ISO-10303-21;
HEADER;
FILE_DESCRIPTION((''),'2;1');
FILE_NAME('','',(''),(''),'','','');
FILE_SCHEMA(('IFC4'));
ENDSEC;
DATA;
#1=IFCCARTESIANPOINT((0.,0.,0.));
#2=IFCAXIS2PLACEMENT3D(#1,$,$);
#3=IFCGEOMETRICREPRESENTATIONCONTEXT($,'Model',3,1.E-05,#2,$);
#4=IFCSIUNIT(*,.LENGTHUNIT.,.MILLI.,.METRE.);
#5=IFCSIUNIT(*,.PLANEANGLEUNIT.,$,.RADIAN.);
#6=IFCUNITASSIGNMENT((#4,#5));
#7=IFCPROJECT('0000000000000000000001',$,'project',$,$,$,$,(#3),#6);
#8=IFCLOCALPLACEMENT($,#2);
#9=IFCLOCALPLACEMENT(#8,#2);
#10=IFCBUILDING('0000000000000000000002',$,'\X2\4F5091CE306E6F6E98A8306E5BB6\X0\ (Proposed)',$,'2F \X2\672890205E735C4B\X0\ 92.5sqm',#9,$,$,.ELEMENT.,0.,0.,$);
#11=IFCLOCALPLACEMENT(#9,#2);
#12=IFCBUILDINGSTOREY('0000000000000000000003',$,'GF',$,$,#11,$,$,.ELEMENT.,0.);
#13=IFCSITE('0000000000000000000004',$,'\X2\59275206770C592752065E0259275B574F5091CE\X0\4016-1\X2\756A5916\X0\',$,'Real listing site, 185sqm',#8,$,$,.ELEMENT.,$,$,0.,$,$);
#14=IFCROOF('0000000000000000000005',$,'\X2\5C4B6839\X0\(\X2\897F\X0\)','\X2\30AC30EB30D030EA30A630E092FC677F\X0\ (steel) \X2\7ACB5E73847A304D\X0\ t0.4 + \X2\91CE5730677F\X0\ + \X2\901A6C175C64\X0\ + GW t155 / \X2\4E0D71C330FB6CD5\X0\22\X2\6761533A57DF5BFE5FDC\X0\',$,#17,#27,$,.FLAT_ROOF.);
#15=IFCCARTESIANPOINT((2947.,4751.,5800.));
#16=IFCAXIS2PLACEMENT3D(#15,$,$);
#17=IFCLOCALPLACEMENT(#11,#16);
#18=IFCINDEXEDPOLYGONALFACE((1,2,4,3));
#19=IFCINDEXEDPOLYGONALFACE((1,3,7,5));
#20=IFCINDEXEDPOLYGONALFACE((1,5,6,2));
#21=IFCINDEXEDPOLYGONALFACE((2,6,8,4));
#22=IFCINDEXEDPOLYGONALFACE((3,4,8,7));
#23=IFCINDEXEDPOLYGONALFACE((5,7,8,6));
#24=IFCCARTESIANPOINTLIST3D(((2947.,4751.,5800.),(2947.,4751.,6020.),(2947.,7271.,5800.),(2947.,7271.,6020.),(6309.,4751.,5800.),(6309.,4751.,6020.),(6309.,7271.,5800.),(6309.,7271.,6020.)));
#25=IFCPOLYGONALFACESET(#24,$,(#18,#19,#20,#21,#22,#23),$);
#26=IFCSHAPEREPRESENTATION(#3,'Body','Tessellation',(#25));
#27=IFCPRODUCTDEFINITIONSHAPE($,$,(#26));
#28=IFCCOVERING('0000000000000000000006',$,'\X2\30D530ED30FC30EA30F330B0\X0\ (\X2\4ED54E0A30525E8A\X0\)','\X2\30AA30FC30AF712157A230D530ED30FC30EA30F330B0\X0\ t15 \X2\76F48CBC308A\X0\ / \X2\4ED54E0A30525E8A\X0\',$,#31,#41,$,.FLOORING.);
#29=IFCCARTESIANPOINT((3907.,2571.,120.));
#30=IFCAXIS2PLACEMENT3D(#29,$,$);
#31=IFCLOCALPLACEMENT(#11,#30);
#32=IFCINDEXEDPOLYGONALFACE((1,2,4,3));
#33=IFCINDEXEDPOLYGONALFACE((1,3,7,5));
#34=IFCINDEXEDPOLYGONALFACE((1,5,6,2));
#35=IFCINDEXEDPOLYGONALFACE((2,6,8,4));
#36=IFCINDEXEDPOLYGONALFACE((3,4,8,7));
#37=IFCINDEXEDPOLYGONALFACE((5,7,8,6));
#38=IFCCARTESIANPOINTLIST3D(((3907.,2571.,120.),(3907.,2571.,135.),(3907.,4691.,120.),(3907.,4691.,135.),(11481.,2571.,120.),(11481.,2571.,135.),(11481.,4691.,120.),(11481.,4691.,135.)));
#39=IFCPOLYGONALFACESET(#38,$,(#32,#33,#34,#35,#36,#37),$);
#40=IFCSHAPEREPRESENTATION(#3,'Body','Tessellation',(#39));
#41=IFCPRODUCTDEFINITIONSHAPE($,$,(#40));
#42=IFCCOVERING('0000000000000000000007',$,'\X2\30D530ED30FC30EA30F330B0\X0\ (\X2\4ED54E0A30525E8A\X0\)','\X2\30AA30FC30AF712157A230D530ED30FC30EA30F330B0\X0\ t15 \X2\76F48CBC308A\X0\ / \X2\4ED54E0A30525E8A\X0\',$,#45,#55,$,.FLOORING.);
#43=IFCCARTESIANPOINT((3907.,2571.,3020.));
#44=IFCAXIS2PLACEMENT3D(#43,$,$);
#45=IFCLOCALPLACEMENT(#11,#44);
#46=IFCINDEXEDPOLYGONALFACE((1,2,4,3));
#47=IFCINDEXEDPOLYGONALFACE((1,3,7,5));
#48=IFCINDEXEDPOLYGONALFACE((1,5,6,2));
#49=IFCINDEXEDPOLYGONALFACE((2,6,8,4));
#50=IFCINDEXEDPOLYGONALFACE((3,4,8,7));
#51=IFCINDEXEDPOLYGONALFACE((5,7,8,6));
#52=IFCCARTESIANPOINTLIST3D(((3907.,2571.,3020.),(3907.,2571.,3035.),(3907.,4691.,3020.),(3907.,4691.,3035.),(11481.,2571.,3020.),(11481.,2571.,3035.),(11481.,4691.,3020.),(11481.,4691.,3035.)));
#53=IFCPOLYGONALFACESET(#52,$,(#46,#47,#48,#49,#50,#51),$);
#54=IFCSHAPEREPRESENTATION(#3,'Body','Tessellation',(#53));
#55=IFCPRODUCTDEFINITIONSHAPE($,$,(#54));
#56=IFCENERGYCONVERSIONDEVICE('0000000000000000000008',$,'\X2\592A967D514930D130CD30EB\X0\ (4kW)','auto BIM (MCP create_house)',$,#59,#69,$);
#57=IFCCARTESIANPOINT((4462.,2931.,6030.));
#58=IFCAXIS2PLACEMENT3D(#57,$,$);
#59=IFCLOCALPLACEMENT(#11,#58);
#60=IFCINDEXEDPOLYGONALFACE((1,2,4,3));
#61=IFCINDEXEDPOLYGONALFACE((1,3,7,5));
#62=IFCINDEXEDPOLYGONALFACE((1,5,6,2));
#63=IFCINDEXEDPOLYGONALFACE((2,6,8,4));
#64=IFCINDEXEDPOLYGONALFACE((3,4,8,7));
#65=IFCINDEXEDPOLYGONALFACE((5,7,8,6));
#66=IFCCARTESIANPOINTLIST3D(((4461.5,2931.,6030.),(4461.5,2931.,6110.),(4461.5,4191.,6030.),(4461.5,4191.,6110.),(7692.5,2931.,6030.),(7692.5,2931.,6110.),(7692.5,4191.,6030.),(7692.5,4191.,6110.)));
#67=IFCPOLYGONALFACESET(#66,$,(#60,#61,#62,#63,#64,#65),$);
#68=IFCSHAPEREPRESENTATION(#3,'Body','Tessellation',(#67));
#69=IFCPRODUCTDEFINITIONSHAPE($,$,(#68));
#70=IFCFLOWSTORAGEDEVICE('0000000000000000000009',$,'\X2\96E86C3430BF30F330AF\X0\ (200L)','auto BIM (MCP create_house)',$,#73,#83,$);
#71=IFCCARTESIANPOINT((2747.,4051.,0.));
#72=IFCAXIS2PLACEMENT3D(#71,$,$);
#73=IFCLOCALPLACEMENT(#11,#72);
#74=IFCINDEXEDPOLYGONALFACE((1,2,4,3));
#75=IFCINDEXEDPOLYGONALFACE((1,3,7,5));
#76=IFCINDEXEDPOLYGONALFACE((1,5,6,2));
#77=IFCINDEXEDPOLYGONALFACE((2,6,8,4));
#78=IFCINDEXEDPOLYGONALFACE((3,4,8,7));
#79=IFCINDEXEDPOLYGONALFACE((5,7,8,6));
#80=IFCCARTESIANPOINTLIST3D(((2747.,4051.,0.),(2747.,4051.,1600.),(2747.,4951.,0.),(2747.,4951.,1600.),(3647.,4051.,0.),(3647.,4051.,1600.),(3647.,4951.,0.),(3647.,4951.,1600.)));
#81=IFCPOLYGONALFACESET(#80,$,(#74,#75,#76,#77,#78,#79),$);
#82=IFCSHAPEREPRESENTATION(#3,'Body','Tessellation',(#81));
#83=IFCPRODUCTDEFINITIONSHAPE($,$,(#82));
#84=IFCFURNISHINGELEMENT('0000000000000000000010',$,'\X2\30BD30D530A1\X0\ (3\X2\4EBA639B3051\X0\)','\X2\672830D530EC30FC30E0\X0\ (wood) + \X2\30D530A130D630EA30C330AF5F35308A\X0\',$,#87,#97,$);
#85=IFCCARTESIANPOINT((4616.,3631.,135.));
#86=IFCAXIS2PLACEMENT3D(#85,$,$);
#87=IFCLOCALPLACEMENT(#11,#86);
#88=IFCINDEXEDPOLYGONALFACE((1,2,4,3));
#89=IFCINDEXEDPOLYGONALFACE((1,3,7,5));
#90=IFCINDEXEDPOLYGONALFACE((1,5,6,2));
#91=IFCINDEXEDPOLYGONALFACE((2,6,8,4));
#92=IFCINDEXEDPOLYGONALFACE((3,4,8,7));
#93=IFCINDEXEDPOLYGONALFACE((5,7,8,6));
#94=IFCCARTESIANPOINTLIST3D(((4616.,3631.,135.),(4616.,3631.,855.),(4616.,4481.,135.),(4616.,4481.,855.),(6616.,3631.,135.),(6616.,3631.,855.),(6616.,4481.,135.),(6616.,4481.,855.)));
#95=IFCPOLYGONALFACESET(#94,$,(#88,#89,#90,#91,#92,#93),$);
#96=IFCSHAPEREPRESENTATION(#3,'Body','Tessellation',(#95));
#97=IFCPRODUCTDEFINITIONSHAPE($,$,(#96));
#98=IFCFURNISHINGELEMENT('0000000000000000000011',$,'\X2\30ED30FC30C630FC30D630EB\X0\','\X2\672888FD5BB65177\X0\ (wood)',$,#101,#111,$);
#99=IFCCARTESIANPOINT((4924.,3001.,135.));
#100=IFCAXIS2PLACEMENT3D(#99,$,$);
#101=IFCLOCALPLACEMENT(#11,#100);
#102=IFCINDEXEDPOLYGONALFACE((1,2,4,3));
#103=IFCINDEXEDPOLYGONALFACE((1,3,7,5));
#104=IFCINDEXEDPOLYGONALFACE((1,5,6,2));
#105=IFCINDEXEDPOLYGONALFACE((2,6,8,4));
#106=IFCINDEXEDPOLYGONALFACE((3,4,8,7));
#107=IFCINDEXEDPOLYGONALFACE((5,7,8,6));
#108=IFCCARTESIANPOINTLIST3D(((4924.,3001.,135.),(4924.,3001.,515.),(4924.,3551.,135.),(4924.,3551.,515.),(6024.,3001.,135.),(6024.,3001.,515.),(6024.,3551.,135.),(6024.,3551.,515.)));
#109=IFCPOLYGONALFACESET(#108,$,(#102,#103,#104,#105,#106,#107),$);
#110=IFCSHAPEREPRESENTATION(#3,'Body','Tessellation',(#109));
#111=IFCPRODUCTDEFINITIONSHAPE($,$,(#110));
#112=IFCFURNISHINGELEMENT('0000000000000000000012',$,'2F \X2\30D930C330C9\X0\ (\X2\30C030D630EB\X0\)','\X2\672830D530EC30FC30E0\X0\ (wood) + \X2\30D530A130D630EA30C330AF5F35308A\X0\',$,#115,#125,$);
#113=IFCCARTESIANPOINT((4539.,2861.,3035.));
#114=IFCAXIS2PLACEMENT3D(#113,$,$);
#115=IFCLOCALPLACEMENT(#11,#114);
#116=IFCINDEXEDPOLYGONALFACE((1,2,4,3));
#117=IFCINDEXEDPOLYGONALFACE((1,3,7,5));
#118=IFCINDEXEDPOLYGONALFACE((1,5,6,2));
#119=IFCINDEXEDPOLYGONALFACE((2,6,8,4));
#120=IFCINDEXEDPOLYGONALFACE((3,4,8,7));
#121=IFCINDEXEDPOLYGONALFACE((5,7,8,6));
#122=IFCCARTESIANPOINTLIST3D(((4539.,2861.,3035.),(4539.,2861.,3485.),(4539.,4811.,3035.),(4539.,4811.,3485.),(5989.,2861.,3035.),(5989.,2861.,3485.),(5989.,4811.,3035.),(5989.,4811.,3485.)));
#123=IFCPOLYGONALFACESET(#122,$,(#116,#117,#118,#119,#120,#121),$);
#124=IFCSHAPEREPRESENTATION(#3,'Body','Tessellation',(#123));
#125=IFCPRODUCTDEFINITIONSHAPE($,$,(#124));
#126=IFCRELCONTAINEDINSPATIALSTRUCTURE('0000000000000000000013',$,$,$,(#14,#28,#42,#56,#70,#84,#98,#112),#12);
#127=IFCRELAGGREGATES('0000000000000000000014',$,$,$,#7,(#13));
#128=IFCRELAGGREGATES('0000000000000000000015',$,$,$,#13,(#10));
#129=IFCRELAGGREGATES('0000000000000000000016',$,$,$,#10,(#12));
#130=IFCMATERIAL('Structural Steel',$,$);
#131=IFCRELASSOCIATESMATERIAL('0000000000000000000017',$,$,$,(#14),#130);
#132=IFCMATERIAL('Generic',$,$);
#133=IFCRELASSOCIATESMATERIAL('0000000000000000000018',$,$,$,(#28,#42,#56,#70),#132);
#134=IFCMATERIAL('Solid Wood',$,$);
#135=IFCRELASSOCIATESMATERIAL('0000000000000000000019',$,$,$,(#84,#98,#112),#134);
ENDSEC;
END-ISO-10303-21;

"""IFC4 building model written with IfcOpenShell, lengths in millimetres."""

from ifc_helpers import new_model, si_unit, frame, frame_2d, origin, place, context, project, spatial, rectangle, extrude, material, element, save


model = new_model("IFC4")

# Units and contexts
model_context = context("Model", 3, precision=1e-05, world=origin())
ifc_project = project(units=[si_unit("LENGTHUNIT", "METRE", prefix="MILLI"), si_unit("PLANEANGLEUNIT", "RADIAN")], contexts=[model_context])

# Site, building, storey
site_placement = place(None, origin())
site = spatial("IfcSite", under=ifc_project, at=site_placement, Name="大分県大分市大字佐野4016-1番外", ObjectType="Real listing site, 185sqm", CompositionType="ELEMENT", RefElevation=0.0)
building_placement = place(site_placement, origin())
building = spatial("IfcBuilding", under=site, at=building_placement, Name="佐野の潮風の家 (Proposed)", ObjectType="2F 木造平屋 92.5sqm", CompositionType="ELEMENT", ElevationOfRefHeight=0.0, ElevationOfTerrain=0.0)
storey_placement = place(building_placement, origin())
storey = spatial("IfcBuildingStorey", under=building, at=storey_placement, Name="GF", CompositionType="ELEMENT", Elevation=0.0)

# Shared definitions
ifc_material_1 = material(Name="Solid Wood")

# Roof
ifc_material_2 = material(Name="Structural Steel")
roof_1_placement = place(storey_placement, frame((2947.0, 4751.0, 5800.0)))
element("IfcRoof", 1, at=roof_1_placement, inside=storey, material=ifc_material_2, Name="屋根(西)", Description="ガルバリウム鋼板 (steel) 立平葺き t0.4 + 野地板 + 通気層 + GW t155 / 不燃・法22条区域対応", PredefinedType="FLAT_ROOF", context=model_context, shape_type="SweptSolid", body=[
    extrude(rectangle(XDim=3362.0, YDim=2520.0, at=frame_2d((1681.0, 1260.0))), frame((2947.0, 4751.0, 5800.0)), (0.0, 0.0, 1.0), 220.0),
])

# Coverings
ifc_material_3 = material(Name="Generic")
covering_1_placement = place(storey_placement, frame((3907.0, 2571.0, 120.0)))
element("IfcCovering", 2, at=covering_1_placement, inside=storey, material=ifc_material_3, Name="フローリング (仕上げ床)", Description="オーク無垢フローリング t15 直貼り / 仕上げ床", PredefinedType="FLOORING", context=model_context, shape_type="SweptSolid", body=[
    extrude(rectangle(XDim=7574.0, YDim=2120.0, at=frame_2d((3787.0, 1060.0))), frame((3907.0, 2571.0, 120.0)), (0.0, 0.0, 1.0), 15.0),
])
covering_2_placement = place(storey_placement, frame((3907.0, 2571.0, 3020.0)))
element("IfcCovering", 3, at=covering_2_placement, inside=storey, material=ifc_material_3, Name="フローリング (仕上げ床)", Description="オーク無垢フローリング t15 直貼り / 仕上げ床", PredefinedType="FLOORING", context=model_context, shape_type="SweptSolid", body=[
    extrude(rectangle(XDim=7574.0, YDim=2120.0, at=frame_2d((3787.0, 1060.0))), frame((3907.0, 2571.0, 3020.0)), (0.0, 0.0, 1.0), 15.0),
])

# Energy conversion device
energy_conversion_device_placement = place(storey_placement, frame((4462.0, 2931.0, 6030.0)))
element("IfcEnergyConversionDevice", 4, at=energy_conversion_device_placement, inside=storey, material=ifc_material_3, Name="太陽光パネル (4kW)", Description="auto BIM (MCP create_house)", context=model_context, shape_type="SweptSolid", body=[
    extrude(rectangle(XDim=3231.0, YDim=1260.0, at=frame_2d((1615.0, 630.0))), frame((4462.0, 2931.0, 6030.0)), (0.0, 0.0, 1.0), 80.0),
])

# Flow storage device
flow_storage_device_placement = place(storey_placement, frame((2747.0, 4051.0, 0.0)))
element("IfcFlowStorageDevice", 5, at=flow_storage_device_placement, inside=storey, material=ifc_material_3, Name="雨水タンク (200L)", Description="auto BIM (MCP create_house)", context=model_context, shape_type="SweptSolid", body=[
    extrude(rectangle(XDim=900.0, YDim=900.0, at=frame_2d((450.0, 450.0))), frame((2747.0, 4051.0, 0.0)), (0.0, 0.0, 1.0), 1600.0),
])

# Furnishing elements
furnishing_1_placement = place(storey_placement, frame((4616.0, 3631.0, 135.0)))
element("IfcFurnishingElement", 6, at=furnishing_1_placement, inside=storey, material=ifc_material_1, Name="ソファ (3人掛け)", Description="木フレーム (wood) + ファブリック張り", context=model_context, shape_type="SweptSolid", body=[
    extrude(rectangle(XDim=2000.0, YDim=850.0, at=frame_2d((1000.0, 425.0))), frame((4616.0, 3631.0, 135.0)), (0.0, 0.0, 1.0), 720.0),
])
furnishing_2_placement = place(storey_placement, frame((4924.0, 3001.0, 135.0)))
element("IfcFurnishingElement", 7, at=furnishing_2_placement, inside=storey, material=ifc_material_1, Name="ローテーブル", Description="木製家具 (wood)", context=model_context, shape_type="SweptSolid", body=[
    extrude(rectangle(XDim=1100.0, YDim=550.0, at=frame_2d((550.0, 275.0))), frame((4924.0, 3001.0, 135.0)), (0.0, 0.0, 1.0), 380.0),
])
furnishing_3_placement = place(storey_placement, frame((4539.0, 2861.0, 3035.0)))
element("IfcFurnishingElement", 8, at=furnishing_3_placement, inside=storey, material=ifc_material_1, Name="2F ベッド (ダブル)", Description="木フレーム (wood) + ファブリック張り", context=model_context, shape_type="SweptSolid", body=[
    extrude(rectangle(XDim=1450.0, YDim=1950.0, at=frame_2d((725.0, 975.0))), frame((4539.0, 2861.0, 3035.0)), (0.0, 0.0, 1.0), 450.0),
])

save(model, "model.ifc")
